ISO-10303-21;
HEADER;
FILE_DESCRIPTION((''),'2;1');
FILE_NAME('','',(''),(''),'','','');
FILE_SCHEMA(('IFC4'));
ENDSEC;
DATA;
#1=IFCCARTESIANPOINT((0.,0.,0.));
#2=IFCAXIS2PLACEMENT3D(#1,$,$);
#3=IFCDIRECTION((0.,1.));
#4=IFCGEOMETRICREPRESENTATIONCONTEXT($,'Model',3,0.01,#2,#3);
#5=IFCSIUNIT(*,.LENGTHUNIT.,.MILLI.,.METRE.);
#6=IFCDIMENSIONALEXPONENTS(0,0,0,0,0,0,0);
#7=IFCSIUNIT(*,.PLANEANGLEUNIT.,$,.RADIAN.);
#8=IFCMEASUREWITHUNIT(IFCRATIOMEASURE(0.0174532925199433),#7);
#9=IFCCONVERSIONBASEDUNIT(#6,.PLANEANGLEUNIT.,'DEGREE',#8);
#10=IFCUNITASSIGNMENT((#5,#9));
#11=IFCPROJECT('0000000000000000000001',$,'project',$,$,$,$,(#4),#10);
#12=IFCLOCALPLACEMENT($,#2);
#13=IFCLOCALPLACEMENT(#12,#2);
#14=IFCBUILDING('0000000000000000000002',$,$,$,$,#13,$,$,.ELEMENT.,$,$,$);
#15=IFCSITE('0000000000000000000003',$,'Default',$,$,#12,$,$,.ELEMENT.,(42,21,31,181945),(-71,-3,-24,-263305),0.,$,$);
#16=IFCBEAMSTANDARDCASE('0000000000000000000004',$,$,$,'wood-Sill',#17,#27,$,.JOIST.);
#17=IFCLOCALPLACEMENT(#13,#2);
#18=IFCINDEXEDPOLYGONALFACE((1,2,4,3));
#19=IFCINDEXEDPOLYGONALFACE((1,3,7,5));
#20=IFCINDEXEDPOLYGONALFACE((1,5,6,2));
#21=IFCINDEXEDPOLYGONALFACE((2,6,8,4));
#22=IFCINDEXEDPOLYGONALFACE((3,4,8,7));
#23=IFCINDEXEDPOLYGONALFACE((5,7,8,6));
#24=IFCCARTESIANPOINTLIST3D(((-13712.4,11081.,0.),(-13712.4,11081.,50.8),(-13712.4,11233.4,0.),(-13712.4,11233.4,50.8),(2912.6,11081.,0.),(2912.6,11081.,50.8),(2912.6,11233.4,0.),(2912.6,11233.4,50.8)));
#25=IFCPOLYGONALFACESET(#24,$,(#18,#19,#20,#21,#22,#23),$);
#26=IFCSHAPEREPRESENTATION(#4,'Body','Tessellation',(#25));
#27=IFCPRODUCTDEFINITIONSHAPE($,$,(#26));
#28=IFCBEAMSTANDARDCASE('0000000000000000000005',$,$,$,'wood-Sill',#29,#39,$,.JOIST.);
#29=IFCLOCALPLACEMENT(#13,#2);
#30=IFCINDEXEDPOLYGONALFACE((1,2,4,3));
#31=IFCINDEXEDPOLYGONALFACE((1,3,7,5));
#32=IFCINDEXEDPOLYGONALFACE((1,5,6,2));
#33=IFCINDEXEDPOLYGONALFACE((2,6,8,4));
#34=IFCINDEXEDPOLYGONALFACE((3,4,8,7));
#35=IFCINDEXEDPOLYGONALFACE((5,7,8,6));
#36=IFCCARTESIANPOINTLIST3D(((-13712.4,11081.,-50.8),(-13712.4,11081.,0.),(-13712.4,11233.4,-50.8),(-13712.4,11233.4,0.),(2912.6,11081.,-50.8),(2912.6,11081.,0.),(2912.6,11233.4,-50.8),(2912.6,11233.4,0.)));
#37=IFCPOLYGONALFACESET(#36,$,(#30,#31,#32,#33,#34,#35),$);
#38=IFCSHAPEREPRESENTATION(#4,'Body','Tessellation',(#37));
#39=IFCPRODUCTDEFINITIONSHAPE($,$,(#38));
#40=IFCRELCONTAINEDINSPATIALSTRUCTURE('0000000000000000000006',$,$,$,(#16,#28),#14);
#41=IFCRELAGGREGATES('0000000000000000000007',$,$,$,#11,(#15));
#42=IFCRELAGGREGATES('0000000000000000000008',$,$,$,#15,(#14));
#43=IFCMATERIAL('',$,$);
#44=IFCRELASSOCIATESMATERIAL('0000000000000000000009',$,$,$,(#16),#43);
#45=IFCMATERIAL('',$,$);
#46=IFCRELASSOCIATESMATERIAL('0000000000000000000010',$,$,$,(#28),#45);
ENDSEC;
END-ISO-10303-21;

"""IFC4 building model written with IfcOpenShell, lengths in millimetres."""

from ifc_helpers import new_model, entity, si_unit, converted_unit, direction, frame, origin, place, context, project, spatial, rectangle, extrude, material, element, save


model = new_model("IFC4")

# Units and contexts
model_context = context("Model", 3, precision=0.01, world=origin(), true_north=direction((0.0, 1.0)))
ifc_project = project(units=[si_unit("LENGTHUNIT", "METRE", prefix="MILLI"), converted_unit("PLANEANGLEUNIT", "DEGREE", entity("IfcRatioMeasure", 0.0174532925199433), si_unit("PLANEANGLEUNIT", "RADIAN"), dimensions=[0, 0, 0, 0, 0, 0, 0])], contexts=[model_context])

# Site, building
site_placement = place(None, origin())
site = spatial("IfcSite", under=ifc_project, at=site_placement, Name="Default", CompositionType="ELEMENT", RefLatitude=(42, 21, 31, 181945), RefLongitude=(-71, -3, -24, -263305), RefElevation=0.0)
building_placement = place(site_placement, origin())
building = spatial("IfcBuilding", under=site, at=building_placement, CompositionType="ELEMENT")

# Shared definitions
placement_1 = place(building_placement, origin())
placement_2 = place(placement_1, frame((2912.6, 11157.2, 0.0), z_axis=(0.0, 0.0, 1.0), x_axis=(-1.0, 0.0, 0.0)))

# Beams
ifc_material_1 = material(Name="")
beam_1_placement = place(placement_2, frame((8312.5, 0.0, 0.0), z_axis=(0.0, 0.0, 1.0), x_axis=(-1.0, 0.0, 0.0)))
element("IfcBeamStandardCase", 1, at=beam_1_placement, inside=building, material=ifc_material_1, ObjectType="wood-Sill", PredefinedType="JOIST", context=model_context, shape_type="SweptSolid", body=[
    extrude(rectangle(XDim=16625.0, YDim=152.4), origin(), (0.0, 0.0, 1.0), 50.8),
])
ifc_material_2 = material(Name="")
beam_2_placement = place(placement_2, frame((8312.5, 0.0, -50.8), z_axis=(0.0, 0.0, 1.0), x_axis=(-1.0, 0.0, 0.0)))
element("IfcBeamStandardCase", 2, at=beam_2_placement, inside=building, material=ifc_material_2, ObjectType="wood-Sill", PredefinedType="JOIST", context=model_context, shape_type="SweptSolid", body=[
    extrude(rectangle(XDim=16625.0, YDim=152.4), origin(), (0.0, 0.0, 1.0), 50.8),
])

save(model, "model.ifc")
